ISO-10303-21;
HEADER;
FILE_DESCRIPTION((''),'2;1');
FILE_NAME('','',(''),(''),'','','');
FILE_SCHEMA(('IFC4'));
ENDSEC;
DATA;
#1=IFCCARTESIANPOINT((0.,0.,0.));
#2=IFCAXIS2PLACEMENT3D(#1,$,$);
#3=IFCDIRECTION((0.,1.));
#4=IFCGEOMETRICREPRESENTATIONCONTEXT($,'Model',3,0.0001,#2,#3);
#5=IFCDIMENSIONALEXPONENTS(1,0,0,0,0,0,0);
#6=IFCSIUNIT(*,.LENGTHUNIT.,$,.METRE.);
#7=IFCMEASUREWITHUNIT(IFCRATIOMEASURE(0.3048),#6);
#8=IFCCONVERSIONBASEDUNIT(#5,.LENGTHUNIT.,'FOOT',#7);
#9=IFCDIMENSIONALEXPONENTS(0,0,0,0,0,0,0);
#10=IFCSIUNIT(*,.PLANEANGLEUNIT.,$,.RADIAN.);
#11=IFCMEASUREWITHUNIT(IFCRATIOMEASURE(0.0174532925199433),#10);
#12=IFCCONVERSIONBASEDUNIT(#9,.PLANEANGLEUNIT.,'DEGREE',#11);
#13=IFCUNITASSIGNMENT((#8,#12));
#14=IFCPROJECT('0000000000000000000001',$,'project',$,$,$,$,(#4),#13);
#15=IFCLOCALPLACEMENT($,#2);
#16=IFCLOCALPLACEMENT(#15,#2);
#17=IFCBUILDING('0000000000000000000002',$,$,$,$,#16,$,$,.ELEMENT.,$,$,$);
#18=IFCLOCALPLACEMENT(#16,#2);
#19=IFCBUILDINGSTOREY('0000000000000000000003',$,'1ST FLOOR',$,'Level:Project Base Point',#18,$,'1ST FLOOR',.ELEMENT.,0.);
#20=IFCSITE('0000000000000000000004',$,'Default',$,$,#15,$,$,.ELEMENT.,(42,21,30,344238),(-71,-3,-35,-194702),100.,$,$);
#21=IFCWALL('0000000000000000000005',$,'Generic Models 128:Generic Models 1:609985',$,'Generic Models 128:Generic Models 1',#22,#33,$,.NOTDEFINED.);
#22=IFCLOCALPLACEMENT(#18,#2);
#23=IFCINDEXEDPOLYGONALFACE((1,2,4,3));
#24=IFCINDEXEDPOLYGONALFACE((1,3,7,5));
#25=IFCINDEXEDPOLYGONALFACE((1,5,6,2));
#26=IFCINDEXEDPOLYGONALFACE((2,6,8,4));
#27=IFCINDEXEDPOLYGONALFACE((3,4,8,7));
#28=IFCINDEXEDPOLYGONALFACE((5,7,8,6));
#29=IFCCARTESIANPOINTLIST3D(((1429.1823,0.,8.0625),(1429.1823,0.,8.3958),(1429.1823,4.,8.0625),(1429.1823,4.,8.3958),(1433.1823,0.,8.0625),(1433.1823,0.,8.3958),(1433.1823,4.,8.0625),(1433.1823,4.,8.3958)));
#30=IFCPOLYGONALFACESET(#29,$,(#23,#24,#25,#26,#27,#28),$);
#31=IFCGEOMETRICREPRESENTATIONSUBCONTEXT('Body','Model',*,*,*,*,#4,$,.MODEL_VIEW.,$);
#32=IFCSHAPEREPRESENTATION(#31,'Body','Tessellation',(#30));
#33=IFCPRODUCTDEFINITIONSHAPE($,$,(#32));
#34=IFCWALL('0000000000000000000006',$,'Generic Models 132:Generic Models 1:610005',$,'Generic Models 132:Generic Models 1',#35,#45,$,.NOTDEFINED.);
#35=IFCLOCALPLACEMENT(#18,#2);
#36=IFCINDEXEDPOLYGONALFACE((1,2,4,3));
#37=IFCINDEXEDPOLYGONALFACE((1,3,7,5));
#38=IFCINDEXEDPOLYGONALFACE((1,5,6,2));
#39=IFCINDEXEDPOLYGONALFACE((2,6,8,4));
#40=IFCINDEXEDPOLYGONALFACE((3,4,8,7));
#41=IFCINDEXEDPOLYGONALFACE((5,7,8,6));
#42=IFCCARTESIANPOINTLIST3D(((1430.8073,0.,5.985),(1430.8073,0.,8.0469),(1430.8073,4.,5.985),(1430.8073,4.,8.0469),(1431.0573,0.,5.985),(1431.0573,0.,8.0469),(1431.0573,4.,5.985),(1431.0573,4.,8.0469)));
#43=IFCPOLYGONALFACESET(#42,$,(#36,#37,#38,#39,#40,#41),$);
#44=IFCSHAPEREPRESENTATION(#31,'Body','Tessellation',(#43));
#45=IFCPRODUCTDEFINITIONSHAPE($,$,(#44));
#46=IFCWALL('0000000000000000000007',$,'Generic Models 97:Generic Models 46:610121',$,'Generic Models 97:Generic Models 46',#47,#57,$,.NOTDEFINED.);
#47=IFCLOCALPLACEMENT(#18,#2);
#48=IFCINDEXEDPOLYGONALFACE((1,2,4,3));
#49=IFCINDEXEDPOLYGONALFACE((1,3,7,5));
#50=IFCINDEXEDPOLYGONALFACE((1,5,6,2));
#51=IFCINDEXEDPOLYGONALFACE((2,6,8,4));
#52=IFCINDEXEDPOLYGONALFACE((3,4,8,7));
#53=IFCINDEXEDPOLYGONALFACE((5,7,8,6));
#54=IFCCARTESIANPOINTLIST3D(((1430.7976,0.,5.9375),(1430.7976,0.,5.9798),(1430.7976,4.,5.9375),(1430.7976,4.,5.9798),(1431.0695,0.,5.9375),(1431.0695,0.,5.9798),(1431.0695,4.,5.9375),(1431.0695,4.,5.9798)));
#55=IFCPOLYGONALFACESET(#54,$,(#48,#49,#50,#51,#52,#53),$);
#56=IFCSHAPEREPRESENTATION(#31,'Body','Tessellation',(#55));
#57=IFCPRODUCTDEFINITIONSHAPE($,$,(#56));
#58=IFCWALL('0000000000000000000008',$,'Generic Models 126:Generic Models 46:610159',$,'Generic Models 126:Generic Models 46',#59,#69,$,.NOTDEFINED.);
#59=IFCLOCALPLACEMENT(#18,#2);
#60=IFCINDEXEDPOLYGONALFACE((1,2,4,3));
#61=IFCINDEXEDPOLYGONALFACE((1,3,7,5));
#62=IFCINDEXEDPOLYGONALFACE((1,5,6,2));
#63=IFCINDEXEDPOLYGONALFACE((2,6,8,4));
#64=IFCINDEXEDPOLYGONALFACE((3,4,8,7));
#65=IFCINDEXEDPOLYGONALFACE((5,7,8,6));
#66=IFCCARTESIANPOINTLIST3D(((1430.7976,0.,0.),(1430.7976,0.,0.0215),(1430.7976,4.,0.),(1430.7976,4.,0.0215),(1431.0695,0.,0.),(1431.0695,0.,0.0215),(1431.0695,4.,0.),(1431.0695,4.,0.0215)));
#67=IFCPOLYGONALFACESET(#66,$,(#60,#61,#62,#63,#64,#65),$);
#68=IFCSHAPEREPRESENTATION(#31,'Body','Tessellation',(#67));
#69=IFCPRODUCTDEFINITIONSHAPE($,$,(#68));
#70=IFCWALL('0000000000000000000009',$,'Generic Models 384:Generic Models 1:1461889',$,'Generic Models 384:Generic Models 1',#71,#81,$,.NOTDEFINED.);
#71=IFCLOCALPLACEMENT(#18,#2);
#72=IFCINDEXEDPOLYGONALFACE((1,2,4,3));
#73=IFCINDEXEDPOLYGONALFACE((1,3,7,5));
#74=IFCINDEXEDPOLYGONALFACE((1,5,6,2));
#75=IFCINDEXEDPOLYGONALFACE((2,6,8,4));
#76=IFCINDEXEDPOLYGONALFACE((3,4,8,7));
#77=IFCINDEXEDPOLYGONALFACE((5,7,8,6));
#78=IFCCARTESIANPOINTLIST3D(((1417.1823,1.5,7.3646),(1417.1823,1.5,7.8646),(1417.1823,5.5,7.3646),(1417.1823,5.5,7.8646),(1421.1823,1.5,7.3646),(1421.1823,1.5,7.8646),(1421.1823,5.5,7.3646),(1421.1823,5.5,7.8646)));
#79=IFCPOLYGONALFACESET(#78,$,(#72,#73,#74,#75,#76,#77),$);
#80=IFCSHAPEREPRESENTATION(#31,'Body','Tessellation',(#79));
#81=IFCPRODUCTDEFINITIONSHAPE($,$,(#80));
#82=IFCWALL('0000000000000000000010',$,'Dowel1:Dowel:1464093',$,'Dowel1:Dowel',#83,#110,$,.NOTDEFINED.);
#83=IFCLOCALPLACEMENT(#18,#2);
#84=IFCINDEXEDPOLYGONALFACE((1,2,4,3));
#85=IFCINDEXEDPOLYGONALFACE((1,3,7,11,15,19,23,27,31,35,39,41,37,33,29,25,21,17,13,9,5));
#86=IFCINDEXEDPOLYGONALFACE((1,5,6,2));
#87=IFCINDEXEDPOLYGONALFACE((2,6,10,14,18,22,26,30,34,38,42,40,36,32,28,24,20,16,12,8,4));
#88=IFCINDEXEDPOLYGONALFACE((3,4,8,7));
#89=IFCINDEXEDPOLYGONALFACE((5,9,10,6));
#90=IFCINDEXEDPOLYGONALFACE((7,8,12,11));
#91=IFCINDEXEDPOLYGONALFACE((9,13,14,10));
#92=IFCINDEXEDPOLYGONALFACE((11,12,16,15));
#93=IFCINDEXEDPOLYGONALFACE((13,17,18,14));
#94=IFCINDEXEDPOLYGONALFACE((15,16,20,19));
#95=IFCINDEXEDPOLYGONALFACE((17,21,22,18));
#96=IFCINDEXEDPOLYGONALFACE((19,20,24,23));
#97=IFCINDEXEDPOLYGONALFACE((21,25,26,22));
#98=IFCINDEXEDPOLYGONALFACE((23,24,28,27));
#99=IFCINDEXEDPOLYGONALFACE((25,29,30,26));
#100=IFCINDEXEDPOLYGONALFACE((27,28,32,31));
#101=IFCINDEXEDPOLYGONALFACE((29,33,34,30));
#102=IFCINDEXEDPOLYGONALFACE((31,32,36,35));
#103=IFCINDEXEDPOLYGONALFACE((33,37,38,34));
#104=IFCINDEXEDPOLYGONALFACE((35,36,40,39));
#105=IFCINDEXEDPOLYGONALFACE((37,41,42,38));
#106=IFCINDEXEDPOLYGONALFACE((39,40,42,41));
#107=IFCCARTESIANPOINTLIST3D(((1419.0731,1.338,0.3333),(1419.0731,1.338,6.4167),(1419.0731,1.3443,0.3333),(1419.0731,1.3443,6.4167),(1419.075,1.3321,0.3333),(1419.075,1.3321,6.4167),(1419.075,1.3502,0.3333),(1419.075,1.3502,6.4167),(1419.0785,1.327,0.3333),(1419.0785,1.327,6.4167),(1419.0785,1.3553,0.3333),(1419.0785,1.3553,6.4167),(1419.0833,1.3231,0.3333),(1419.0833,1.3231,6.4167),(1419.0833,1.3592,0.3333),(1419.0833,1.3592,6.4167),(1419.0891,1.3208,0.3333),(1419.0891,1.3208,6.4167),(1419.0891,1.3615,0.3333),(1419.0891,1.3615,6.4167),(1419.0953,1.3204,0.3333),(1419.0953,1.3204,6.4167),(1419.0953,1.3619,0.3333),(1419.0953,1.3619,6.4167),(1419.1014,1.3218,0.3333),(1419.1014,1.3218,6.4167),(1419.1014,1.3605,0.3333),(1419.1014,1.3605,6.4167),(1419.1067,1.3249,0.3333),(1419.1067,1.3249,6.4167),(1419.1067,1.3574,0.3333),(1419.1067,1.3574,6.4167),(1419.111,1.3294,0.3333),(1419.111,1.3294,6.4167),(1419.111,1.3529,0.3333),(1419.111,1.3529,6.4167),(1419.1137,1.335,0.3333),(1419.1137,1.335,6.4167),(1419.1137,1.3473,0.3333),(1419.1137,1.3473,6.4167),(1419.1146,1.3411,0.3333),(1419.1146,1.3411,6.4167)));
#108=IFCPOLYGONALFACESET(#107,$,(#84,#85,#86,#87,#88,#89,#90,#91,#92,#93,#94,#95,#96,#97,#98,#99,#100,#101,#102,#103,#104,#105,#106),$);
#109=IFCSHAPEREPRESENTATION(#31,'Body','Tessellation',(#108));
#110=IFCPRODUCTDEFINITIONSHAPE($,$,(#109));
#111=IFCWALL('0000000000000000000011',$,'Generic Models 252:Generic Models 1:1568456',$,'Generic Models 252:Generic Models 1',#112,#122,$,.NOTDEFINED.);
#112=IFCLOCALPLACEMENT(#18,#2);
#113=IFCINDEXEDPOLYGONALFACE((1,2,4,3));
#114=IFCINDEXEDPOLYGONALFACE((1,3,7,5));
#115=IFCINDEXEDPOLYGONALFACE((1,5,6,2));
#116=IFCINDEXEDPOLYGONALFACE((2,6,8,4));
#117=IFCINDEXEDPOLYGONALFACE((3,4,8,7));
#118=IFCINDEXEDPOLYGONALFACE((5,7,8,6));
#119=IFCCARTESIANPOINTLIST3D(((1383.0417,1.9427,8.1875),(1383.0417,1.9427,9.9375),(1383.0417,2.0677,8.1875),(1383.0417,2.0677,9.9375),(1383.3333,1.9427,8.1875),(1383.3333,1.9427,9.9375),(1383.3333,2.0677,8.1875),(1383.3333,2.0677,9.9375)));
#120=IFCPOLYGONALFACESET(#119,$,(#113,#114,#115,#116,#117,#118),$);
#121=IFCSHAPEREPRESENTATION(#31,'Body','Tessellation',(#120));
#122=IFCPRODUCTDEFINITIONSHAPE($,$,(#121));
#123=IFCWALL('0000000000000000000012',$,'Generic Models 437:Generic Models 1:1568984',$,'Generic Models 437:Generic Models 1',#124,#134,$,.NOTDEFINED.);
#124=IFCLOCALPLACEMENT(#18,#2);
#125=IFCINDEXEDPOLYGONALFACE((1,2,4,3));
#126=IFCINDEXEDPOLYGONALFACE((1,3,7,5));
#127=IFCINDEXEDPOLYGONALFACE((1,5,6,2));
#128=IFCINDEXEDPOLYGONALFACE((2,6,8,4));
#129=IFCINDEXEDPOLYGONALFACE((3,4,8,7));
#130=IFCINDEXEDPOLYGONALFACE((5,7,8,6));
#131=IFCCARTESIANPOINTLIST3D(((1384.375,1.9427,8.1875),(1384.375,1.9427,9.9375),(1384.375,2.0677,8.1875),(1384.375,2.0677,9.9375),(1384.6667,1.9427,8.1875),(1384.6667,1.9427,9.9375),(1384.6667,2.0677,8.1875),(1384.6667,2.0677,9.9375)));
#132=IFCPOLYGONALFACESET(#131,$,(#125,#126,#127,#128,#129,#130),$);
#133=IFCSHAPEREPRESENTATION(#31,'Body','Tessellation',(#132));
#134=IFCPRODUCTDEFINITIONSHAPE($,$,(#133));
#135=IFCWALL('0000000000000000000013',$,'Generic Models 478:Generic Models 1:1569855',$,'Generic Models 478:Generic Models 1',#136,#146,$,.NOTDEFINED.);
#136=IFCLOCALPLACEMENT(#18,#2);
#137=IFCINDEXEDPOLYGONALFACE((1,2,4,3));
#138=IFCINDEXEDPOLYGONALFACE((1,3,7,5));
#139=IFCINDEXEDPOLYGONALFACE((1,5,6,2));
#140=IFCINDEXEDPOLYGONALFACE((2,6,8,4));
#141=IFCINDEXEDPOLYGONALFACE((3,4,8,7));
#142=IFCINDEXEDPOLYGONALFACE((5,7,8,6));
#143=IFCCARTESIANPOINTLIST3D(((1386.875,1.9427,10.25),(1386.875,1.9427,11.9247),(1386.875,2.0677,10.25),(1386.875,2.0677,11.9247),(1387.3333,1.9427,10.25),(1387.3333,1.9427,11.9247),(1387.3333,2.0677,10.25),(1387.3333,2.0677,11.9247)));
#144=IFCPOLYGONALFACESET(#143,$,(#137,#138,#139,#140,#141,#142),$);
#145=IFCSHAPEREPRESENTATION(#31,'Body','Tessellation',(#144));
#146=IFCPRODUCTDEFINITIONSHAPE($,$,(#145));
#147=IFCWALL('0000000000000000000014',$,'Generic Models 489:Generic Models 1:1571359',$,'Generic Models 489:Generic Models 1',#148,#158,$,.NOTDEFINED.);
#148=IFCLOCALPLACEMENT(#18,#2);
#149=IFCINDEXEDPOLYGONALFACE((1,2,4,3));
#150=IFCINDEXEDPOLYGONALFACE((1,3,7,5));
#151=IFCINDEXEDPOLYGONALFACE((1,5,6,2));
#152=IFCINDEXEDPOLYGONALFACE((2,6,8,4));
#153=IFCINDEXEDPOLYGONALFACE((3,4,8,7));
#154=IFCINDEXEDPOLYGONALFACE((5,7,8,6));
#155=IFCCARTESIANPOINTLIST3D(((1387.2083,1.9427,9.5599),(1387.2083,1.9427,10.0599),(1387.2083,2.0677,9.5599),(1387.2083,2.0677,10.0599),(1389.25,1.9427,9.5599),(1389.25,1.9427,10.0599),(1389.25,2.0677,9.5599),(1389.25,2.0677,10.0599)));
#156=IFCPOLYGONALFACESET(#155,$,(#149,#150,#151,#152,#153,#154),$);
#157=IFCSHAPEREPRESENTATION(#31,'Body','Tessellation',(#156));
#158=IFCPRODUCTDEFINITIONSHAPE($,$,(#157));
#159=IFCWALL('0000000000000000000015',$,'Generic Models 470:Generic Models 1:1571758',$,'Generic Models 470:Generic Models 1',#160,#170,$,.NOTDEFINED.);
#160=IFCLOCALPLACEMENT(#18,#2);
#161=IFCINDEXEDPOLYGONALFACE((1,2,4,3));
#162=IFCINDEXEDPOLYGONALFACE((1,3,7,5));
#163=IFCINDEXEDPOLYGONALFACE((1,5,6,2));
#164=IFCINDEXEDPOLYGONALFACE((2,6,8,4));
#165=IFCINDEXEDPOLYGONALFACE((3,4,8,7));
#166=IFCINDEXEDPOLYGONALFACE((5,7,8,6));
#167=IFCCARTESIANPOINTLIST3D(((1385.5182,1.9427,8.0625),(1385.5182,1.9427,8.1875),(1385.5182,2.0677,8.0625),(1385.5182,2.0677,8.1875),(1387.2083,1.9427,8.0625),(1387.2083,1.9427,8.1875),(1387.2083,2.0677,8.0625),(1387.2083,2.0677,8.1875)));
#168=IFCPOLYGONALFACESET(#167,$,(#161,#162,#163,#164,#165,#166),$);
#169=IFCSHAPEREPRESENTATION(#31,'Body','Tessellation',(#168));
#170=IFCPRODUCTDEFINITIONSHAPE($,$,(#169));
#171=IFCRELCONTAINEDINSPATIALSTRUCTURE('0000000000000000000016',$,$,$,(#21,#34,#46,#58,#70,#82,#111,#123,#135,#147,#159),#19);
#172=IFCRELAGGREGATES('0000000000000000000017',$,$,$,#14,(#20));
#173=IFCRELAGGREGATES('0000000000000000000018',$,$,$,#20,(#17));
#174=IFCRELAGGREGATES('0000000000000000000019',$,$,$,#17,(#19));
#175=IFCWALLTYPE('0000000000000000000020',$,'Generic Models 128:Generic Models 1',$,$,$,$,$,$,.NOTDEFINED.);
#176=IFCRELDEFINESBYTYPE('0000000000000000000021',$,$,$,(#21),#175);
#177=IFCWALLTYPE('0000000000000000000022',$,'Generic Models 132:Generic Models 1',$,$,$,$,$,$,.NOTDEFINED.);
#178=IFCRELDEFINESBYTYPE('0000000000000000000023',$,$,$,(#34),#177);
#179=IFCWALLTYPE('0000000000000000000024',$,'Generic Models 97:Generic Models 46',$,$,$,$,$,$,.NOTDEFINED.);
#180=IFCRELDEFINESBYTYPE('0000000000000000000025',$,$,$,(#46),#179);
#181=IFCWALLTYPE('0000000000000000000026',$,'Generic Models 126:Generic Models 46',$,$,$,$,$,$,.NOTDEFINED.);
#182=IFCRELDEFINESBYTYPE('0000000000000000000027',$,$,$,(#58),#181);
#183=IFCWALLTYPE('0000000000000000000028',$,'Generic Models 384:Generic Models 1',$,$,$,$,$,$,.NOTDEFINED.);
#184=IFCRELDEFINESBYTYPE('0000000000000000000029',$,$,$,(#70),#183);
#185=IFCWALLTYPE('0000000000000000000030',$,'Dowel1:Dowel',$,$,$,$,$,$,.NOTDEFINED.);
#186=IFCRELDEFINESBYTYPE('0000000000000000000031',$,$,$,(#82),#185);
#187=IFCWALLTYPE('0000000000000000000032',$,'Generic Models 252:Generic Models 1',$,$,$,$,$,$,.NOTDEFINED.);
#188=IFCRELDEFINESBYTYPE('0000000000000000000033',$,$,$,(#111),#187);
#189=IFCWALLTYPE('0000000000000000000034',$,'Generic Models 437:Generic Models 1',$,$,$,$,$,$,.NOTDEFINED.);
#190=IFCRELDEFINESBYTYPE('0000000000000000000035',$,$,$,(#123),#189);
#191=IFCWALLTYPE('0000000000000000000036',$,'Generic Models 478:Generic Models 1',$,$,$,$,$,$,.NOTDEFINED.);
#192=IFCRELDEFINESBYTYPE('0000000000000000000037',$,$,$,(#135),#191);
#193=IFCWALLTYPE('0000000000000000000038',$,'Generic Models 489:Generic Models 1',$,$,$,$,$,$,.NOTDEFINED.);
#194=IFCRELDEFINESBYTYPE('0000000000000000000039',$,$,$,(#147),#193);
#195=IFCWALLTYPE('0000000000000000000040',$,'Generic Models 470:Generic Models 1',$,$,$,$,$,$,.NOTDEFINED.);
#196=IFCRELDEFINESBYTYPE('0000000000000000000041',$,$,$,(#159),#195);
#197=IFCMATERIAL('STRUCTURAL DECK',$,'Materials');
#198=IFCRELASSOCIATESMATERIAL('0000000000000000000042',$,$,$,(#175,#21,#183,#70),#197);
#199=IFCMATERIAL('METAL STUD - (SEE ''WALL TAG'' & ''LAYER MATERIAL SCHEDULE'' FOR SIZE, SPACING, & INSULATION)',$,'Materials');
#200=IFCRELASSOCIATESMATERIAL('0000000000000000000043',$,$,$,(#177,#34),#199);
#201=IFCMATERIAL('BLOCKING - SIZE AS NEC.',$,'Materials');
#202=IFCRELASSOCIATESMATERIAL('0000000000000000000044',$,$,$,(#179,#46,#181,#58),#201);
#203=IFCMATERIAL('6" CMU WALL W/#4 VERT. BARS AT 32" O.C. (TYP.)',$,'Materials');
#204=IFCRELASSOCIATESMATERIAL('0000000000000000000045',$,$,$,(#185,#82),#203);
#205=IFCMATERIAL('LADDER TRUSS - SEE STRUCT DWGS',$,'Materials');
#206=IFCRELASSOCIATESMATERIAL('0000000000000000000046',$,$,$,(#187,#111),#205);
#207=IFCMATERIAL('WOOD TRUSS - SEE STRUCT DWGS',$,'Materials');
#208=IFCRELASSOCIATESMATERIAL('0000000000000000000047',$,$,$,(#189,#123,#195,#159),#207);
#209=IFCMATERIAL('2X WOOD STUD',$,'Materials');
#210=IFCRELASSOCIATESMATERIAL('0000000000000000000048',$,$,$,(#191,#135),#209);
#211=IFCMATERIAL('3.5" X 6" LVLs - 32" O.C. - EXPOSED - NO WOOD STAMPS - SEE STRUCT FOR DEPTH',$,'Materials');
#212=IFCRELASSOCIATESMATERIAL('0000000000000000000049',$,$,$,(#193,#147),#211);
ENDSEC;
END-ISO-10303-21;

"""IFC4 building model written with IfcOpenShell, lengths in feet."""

from ifc_helpers import new_model, entity, si_unit, converted_unit, direction, frame, frame_2d, origin, origin_2d_with_axis, place, context, subcontext, project, spatial, rectangle, circle, extrude, material, type_object, element, save


model = new_model("IFC4")

# Units and contexts
model_context = context("Model", 3, precision=0.0001, world=origin(), true_north=direction((0.0, 1.0)))
body_context = subcontext(model_context, "Body", "Model", "MODEL_VIEW")
ifc_project = project(units=[converted_unit("LENGTHUNIT", "FOOT", entity("IfcRatioMeasure", 0.3048), si_unit("LENGTHUNIT", "METRE"), dimensions=[1, 0, 0, 0, 0, 0, 0]), converted_unit("PLANEANGLEUNIT", "DEGREE", entity("IfcRatioMeasure", 0.0174532925199433), si_unit("PLANEANGLEUNIT", "RADIAN"), dimensions=[0, 0, 0, 0, 0, 0, 0])], contexts=[model_context])

# Site, building, storey
site_placement = place(None, origin())
site = spatial("IfcSite", under=ifc_project, at=site_placement, Name="Default", CompositionType="ELEMENT", RefLatitude=(42, 21, 30, 344238), RefLongitude=(-71, -3, -35, -194702), RefElevation=100.0)
building_placement = place(site_placement, origin())
building = spatial("IfcBuilding", under=site, at=building_placement, CompositionType="ELEMENT")
storey_placement = place(building_placement, origin())
storey = spatial("IfcBuildingStorey", under=building, at=storey_placement, Name="1ST FLOOR", ObjectType="Level:Project Base Point", LongName="1ST FLOOR", CompositionType="ELEMENT", Elevation=0.0)

# Walls
ifc_material_1 = material(Name="STRUCTURAL DECK", Category="Materials")
wall_type_1 = type_object("IfcWallType", Name="Generic Models 128:Generic Models 1", PredefinedType="NOTDEFINED", material=ifc_material_1)
wall_1_placement = place(storey_placement, frame((1429.1823, 0.0, 8.0625), z_axis=(0.0, 0.0, 1.0), x_axis=(0.0, 1.0, 0.0)))
element("IfcWall", 1, at=wall_1_placement, inside=storey, type_object=wall_type_1, material=ifc_material_1, Name="Generic Models 128:Generic Models 1:609985", ObjectType="Generic Models 128:Generic Models 1", PredefinedType="NOTDEFINED", context=body_context, shape_type="SweptSolid", body=[
    extrude(rectangle(XDim=4.0, YDim=4.0, at=origin_2d_with_axis()), frame((2.0, -2.0, 0.0)), (0.0, 0.0, 1.0), 0.3333),
])
ifc_material_2 = material(Name="METAL STUD - (SEE 'WALL TAG' & 'LAYER MATERIAL SCHEDULE' FOR SIZE, SPACING, & INSULATION)", Category="Materials")
wall_type_2 = type_object("IfcWallType", Name="Generic Models 132:Generic Models 1", PredefinedType="NOTDEFINED", material=ifc_material_2)
wall_2_placement = place(storey_placement, frame((1430.8073, 0.0, 5.985), z_axis=(0.0, 0.0, 1.0), x_axis=(0.0, 1.0, 0.0)))
element("IfcWall", 2, at=wall_2_placement, inside=storey, type_object=wall_type_2, material=ifc_material_2, Name="Generic Models 132:Generic Models 1:610005", ObjectType="Generic Models 132:Generic Models 1", PredefinedType="NOTDEFINED", context=body_context, shape_type="SweptSolid", body=[
    extrude(rectangle(XDim=0.25, YDim=4.0, at=frame_2d((0.0, 0.0), x_axis=(1.0, 0.0))), frame((2.0, -0.125, 0.0), z_axis=(0.0, 0.0, 1.0), x_axis=(0.0, 1.0, 0.0)), (0.0, 0.0, 1.0), 2.0618),
])
ifc_material_3 = material(Name="BLOCKING - SIZE AS NEC.", Category="Materials")
wall_type_3 = type_object("IfcWallType", Name="Generic Models 97:Generic Models 46", PredefinedType="NOTDEFINED", material=ifc_material_3)
wall_3_placement = place(storey_placement, frame((1430.7976, 0.0, 5.9375), z_axis=(0.0, 0.0, 1.0), x_axis=(0.0, 1.0, 0.0)))
element("IfcWall", 3, at=wall_3_placement, inside=storey, type_object=wall_type_3, material=ifc_material_3, Name="Generic Models 97:Generic Models 46:610121", ObjectType="Generic Models 97:Generic Models 46", PredefinedType="NOTDEFINED", context=body_context, shape_type="SweptSolid", body=[
    extrude(rectangle(XDim=4.0, YDim=0.2719, at=frame_2d((0.0, 0.0), x_axis=(1.0, 0.0))), frame((2.0, -0.136, 0.0)), (0.0, 0.0, 1.0), 0.0423),
])
wall_type_4 = type_object("IfcWallType", Name="Generic Models 126:Generic Models 46", PredefinedType="NOTDEFINED", material=ifc_material_3)
wall_4_placement = place(storey_placement, frame((1430.7976, 0.0, 0.0), z_axis=(0.0, 0.0, 1.0), x_axis=(0.0, 1.0, 0.0)))
element("IfcWall", 4, at=wall_4_placement, inside=storey, type_object=wall_type_4, material=ifc_material_3, Name="Generic Models 126:Generic Models 46:610159", ObjectType="Generic Models 126:Generic Models 46", PredefinedType="NOTDEFINED", context=body_context, shape_type="SweptSolid", body=[
    extrude(rectangle(XDim=4.0, YDim=0.2719, at=frame_2d((0.0, 0.0), x_axis=(1.0, 0.0))), frame((2.0, -0.136, 0.0)), (0.0, 0.0, 1.0), 0.0215),
])
wall_type_5 = type_object("IfcWallType", Name="Generic Models 384:Generic Models 1", PredefinedType="NOTDEFINED", material=ifc_material_1)
wall_5_placement = place(storey_placement, frame((1417.1823, 1.5, 7.3646), z_axis=(0.0, 0.0, 1.0), x_axis=(0.0, 1.0, 0.0)))
element("IfcWall", 5, at=wall_5_placement, inside=storey, type_object=wall_type_5, material=ifc_material_1, Name="Generic Models 384:Generic Models 1:1461889", ObjectType="Generic Models 384:Generic Models 1", PredefinedType="NOTDEFINED", context=body_context, shape_type="SweptSolid", body=[
    extrude(rectangle(XDim=4.0, YDim=4.0, at=frame_2d((0.0, 0.0), x_axis=(1.0, 0.0))), frame((2.0, -2.0, 0.0)), (0.0, 0.0, 1.0), 0.5),
])
ifc_material_4 = material(Name="6\" CMU WALL W/#4 VERT. BARS AT 32\" O.C. (TYP.)", Category="Materials")
wall_type_6 = type_object("IfcWallType", Name="Dowel1:Dowel", PredefinedType="NOTDEFINED", material=ifc_material_4)
wall_6_placement = place(storey_placement, frame((1419.0729, 1.3203, 0.3333), z_axis=(0.0, 0.0, 1.0), x_axis=(0.0, 1.0, 0.0)))
element("IfcWall", 6, at=wall_6_placement, inside=storey, type_object=wall_type_6, material=ifc_material_4, Name="Dowel1:Dowel:1464093", ObjectType="Dowel1:Dowel", PredefinedType="NOTDEFINED", context=body_context, shape_type="SweptSolid", body=[
    extrude(circle(Radius=0.0208, at=frame_2d((0.0, 0.0), x_axis=(1.0, 0.0))), frame((0.0208, -0.0208, 0.0), z_axis=(0.0, 0.0, 1.0), x_axis=(0.0, -1.0, 0.0)), (0.0, 0.0, 1.0), 6.0833),
])
ifc_material_5 = material(Name="LADDER TRUSS - SEE STRUCT DWGS", Category="Materials")
wall_type_7 = type_object("IfcWallType", Name="Generic Models 252:Generic Models 1", PredefinedType="NOTDEFINED", material=ifc_material_5)
wall_7_placement = place(storey_placement, frame((1383.0417, 1.9427, 8.1875)))
element("IfcWall", 7, at=wall_7_placement, inside=storey, type_object=wall_type_7, material=ifc_material_5, Name="Generic Models 252:Generic Models 1:1568456", ObjectType="Generic Models 252:Generic Models 1", PredefinedType="NOTDEFINED", context=body_context, shape_type="SweptSolid", body=[
    extrude(rectangle(XDim=0.125, YDim=0.2917, at=frame_2d((0.0, 0.0), x_axis=(1.0, 0.0))), frame((0.1458, 0.0625, 0.0), z_axis=(0.0, 0.0, 1.0), x_axis=(0.0, 1.0, 0.0)), (0.0, 0.0, 1.0), 1.75),
])
ifc_material_6 = material(Name="WOOD TRUSS - SEE STRUCT DWGS", Category="Materials")
wall_type_8 = type_object("IfcWallType", Name="Generic Models 437:Generic Models 1", PredefinedType="NOTDEFINED", material=ifc_material_6)
wall_8_placement = place(storey_placement, frame((1384.375, 1.9427, 8.1875)))
element("IfcWall", 8, at=wall_8_placement, inside=storey, type_object=wall_type_8, material=ifc_material_6, Name="Generic Models 437:Generic Models 1:1568984", ObjectType="Generic Models 437:Generic Models 1", PredefinedType="NOTDEFINED", context=body_context, shape_type="SweptSolid", body=[
    extrude(rectangle(XDim=0.125, YDim=0.2917, at=frame_2d((0.0, 0.0), x_axis=(1.0, 0.0))), frame((0.1458, 0.0625, 0.0), z_axis=(0.0, 0.0, 1.0), x_axis=(0.0, 1.0, 0.0)), (0.0, 0.0, 1.0), 1.75),
])
ifc_material_7 = material(Name="2X WOOD STUD", Category="Materials")
wall_type_9 = type_object("IfcWallType", Name="Generic Models 478:Generic Models 1", PredefinedType="NOTDEFINED", material=ifc_material_7)
wall_9_placement = place(storey_placement, frame((1386.875, 1.9427, 10.25)))
element("IfcWall", 9, at=wall_9_placement, inside=storey, type_object=wall_type_9, material=ifc_material_7, Name="Generic Models 478:Generic Models 1:1569855", ObjectType="Generic Models 478:Generic Models 1", PredefinedType="NOTDEFINED", context=body_context, shape_type="SweptSolid", body=[
    extrude(rectangle(XDim=0.125, YDim=0.4583, at=frame_2d((0.0, 0.0), x_axis=(1.0, 0.0))), frame((0.2292, 0.0625, 0.0), z_axis=(0.0, 0.0, 1.0), x_axis=(0.0, 1.0, 0.0)), (0.0, 0.0, 1.0), 1.6747),
])
ifc_material_8 = material(Name="3.5\" X 6\" LVLs - 32\" O.C. - EXPOSED - NO WOOD STAMPS - SEE STRUCT FOR DEPTH", Category="Materials")
wall_type_10 = type_object("IfcWallType", Name="Generic Models 489:Generic Models 1", PredefinedType="NOTDEFINED", material=ifc_material_8)
wall_10_placement = place(storey_placement, frame((1387.2083, 1.9427, 9.5599)))
element("IfcWall", 10, at=wall_10_placement, inside=storey, type_object=wall_type_10, material=ifc_material_8, Name="Generic Models 489:Generic Models 1:1571359", ObjectType="Generic Models 489:Generic Models 1", PredefinedType="NOTDEFINED", context=body_context, shape_type="SweptSolid", body=[
    extrude(rectangle(XDim=0.125, YDim=2.0417, at=frame_2d((0.0, 0.0), x_axis=(1.0, 0.0))), frame((1.0208, 0.0625, 0.0), z_axis=(0.0, 0.0, 1.0), x_axis=(0.0, 1.0, 0.0)), (0.0, 0.0, 1.0), 0.5),
])
wall_type_11 = type_object("IfcWallType", Name="Generic Models 470:Generic Models 1", PredefinedType="NOTDEFINED", material=ifc_material_6)
wall_11_placement = place(storey_placement, frame((1385.5182, 1.9427, 8.0625)))
element("IfcWall", 11, at=wall_11_placement, inside=storey, type_object=wall_type_11, material=ifc_material_6, Name="Generic Models 470:Generic Models 1:1571758", ObjectType="Generic Models 470:Generic Models 1", PredefinedType="NOTDEFINED", context=body_context, shape_type="SweptSolid", body=[
    extrude(rectangle(XDim=0.125, YDim=1.6902, at=frame_2d((0.0, 0.0), x_axis=(1.0, 0.0))), frame((0.8451, 0.0625, 0.0), z_axis=(0.0, 0.0, 1.0), x_axis=(0.0, 1.0, 0.0)), (0.0, 0.0, 1.0), 0.125),
])

save(model, "model.ifc")
